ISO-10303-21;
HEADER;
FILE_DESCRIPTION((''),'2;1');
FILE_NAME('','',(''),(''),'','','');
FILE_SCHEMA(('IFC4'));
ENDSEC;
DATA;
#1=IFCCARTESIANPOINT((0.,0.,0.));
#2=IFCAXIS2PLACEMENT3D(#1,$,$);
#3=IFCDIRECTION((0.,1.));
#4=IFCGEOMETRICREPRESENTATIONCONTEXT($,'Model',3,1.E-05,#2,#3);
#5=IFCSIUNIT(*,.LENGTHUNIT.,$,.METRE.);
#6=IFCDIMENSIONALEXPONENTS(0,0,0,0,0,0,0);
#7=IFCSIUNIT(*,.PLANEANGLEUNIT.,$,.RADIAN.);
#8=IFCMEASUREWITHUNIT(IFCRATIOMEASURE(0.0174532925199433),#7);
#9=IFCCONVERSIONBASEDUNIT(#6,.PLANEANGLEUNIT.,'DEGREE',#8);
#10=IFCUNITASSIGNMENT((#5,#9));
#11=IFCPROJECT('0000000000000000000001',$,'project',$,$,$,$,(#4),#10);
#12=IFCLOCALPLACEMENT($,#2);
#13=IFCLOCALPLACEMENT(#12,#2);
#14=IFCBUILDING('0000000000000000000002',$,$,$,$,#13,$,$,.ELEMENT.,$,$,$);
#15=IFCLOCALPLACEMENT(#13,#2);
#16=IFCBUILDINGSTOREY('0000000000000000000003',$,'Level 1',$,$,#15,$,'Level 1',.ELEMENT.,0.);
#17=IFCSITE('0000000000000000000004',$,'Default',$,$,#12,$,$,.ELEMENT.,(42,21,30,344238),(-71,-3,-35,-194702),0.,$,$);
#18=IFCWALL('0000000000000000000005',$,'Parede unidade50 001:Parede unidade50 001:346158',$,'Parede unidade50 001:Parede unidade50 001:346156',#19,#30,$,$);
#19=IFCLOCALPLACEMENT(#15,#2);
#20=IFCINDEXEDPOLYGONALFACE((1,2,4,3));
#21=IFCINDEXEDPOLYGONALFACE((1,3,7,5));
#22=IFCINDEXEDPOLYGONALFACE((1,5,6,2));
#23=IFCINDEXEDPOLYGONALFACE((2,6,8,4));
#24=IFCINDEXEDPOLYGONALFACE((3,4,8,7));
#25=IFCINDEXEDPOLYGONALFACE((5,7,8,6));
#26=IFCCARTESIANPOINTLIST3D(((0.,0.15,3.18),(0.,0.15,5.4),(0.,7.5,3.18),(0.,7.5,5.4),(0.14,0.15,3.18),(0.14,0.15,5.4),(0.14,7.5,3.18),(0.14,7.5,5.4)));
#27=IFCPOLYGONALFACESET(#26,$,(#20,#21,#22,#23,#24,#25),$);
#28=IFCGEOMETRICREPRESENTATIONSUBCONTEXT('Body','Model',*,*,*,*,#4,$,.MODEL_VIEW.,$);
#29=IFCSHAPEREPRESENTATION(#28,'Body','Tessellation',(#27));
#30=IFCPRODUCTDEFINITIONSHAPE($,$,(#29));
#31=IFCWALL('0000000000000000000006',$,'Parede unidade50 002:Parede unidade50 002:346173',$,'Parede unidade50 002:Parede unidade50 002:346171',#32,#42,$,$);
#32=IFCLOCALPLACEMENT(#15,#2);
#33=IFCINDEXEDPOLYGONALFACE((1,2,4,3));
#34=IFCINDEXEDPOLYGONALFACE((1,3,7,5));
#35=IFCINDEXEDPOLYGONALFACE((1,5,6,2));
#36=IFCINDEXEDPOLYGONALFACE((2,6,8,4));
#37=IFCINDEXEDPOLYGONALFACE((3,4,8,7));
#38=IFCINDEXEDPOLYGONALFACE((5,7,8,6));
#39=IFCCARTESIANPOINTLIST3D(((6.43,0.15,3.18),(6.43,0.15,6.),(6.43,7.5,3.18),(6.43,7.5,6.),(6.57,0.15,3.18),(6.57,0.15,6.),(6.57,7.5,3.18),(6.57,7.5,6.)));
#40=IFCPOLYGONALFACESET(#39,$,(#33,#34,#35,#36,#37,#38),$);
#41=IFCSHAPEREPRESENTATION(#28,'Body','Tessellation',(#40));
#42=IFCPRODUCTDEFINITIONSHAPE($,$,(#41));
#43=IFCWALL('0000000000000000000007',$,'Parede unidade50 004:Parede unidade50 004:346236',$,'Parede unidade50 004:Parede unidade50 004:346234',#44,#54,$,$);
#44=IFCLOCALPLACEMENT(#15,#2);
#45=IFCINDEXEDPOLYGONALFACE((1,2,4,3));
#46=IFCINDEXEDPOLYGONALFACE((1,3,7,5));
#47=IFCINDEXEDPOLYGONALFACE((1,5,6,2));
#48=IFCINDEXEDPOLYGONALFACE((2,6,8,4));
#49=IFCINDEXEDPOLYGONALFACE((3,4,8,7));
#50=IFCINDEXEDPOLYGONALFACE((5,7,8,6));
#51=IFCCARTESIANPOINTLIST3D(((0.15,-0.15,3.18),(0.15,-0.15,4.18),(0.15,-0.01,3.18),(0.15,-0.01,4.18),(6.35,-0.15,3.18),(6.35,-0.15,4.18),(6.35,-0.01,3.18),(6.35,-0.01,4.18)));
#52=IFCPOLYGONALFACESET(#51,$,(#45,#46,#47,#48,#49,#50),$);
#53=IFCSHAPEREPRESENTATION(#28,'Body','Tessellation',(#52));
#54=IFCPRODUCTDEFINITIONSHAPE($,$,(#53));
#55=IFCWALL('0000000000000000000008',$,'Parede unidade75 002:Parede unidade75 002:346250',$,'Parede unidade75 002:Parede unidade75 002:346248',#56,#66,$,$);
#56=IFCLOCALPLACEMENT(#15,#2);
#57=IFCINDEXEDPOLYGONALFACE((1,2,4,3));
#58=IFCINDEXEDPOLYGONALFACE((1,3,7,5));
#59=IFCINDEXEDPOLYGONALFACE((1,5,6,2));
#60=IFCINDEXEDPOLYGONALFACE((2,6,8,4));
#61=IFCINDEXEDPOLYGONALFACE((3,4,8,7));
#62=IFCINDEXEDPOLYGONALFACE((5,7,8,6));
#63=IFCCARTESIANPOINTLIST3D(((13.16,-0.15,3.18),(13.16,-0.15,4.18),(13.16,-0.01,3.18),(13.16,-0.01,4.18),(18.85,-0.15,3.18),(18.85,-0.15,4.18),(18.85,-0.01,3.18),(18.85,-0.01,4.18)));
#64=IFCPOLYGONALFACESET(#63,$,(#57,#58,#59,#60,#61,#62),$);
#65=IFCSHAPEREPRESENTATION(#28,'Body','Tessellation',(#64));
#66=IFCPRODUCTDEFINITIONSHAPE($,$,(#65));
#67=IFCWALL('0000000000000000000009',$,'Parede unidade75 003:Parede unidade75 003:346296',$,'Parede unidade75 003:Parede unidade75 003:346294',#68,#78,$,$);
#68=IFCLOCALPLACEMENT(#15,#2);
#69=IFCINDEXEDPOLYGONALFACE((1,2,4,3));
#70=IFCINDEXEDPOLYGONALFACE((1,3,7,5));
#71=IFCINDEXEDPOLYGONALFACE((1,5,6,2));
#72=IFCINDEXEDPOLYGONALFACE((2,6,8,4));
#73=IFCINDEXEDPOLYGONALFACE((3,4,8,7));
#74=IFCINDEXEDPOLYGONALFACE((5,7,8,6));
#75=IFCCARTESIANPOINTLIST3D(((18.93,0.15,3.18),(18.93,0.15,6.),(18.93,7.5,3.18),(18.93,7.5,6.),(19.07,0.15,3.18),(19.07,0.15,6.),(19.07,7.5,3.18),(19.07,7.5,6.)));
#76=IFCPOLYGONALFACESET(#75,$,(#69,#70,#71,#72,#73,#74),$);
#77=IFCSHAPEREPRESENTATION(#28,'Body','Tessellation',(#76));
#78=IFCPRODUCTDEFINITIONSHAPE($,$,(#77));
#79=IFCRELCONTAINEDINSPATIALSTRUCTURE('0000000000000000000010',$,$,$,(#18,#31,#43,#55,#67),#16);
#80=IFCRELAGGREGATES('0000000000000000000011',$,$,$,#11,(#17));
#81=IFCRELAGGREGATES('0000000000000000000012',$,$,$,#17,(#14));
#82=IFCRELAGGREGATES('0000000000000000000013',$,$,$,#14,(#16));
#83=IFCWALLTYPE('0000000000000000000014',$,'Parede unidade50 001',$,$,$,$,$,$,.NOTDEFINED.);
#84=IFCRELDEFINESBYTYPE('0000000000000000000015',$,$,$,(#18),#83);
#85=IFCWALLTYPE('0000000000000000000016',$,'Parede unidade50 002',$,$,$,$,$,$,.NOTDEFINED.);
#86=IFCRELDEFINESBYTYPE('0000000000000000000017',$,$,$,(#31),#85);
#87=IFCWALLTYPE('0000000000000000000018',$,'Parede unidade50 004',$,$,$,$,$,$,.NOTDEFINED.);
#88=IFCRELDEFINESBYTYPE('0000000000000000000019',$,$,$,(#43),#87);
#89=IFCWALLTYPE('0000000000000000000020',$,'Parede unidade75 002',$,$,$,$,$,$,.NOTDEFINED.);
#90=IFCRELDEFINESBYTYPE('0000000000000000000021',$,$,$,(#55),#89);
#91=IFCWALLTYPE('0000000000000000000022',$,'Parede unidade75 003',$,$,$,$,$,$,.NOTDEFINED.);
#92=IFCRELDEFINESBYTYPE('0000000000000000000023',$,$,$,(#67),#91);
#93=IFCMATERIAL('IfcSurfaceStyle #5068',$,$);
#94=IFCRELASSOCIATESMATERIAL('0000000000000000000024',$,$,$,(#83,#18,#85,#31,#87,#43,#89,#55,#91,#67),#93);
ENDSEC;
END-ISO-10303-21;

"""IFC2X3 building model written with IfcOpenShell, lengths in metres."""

from ifc_helpers import new_model, entity, si_unit, converted_unit, direction, frame, frame_2d, origin, origin_2d_with_axis, place, context, subcontext, project, spatial, rectangle, extrude, material, type_object, element, save


model = new_model("IFC2X3")

# Units and contexts
model_context = context("Model", 3, precision=1e-05, world=origin(), true_north=direction((0.0, 1.0)))
body_context = subcontext(model_context, "Body", "Model", "MODEL_VIEW")
ifc_project = project(units=[si_unit("LENGTHUNIT", "METRE"), converted_unit("PLANEANGLEUNIT", "DEGREE", entity("IfcRatioMeasure", 0.0174532925199433), si_unit("PLANEANGLEUNIT", "RADIAN"), dimensions=[0, 0, 0, 0, 0, 0, 0])], contexts=[model_context])

# Site, building, storey
site_placement = place(None, origin())
site = spatial("IfcSite", under=ifc_project, at=site_placement, Name="Default", CompositionType="ELEMENT", RefLatitude=(42, 21, 30, 344238), RefLongitude=(-71, -3, -35, -194702), RefElevation=0.0)
building_placement = place(site_placement, origin())
building = spatial("IfcBuilding", under=site, at=building_placement, CompositionType="ELEMENT")
storey_placement = place(building_placement, origin())
storey = spatial("IfcBuildingStorey", under=building, at=storey_placement, Name="Level 1", LongName="Level 1", CompositionType="ELEMENT", Elevation=0.0)

# Walls
ifc_material_1 = material(Name="IfcSurfaceStyle #5068")
wall_type_1 = type_object("IfcWallType", Name="Parede unidade50 001", PredefinedType="NOTDEFINED", material=ifc_material_1)
wall_1_placement = place(storey_placement, frame((0.0, 0.15, 3.18), z_axis=(0.0, 0.0, 1.0), x_axis=(0.0, 1.0, 0.0)))
element("IfcWall", 1, at=wall_1_placement, inside=storey, type_object=wall_type_1, material=ifc_material_1, Name="Parede unidade50 001:Parede unidade50 001:346158", ObjectType="Parede unidade50 001:Parede unidade50 001:346156", context=body_context, shape_type="SweptSolid", body=[
    extrude(rectangle(XDim=0.14, YDim=7.35, at=origin_2d_with_axis()), frame((3.675, -0.07, 0.0), z_axis=(0.0, 0.0, 1.0), x_axis=(0.0, 1.0, 0.0)), (0.0, 0.0, 1.0), 2.22),
])
wall_type_2 = type_object("IfcWallType", Name="Parede unidade50 002", PredefinedType="NOTDEFINED", material=ifc_material_1)
wall_2_placement = place(storey_placement, frame((6.43, 0.15, 3.18), z_axis=(0.0, 0.0, 1.0), x_axis=(0.0, 1.0, 0.0)))
element("IfcWall", 2, at=wall_2_placement, inside=storey, type_object=wall_type_2, material=ifc_material_1, Name="Parede unidade50 002:Parede unidade50 002:346173", ObjectType="Parede unidade50 002:Parede unidade50 002:346171", context=body_context, shape_type="SweptSolid", body=[
    extrude(rectangle(XDim=0.14, YDim=7.35, at=origin_2d_with_axis()), frame((3.675, -0.07, 0.0), z_axis=(0.0, 0.0, 1.0), x_axis=(0.0, -1.0, 0.0)), (0.0, 0.0, 1.0), 2.82),
])

# Walls
wall_type_3 = type_object("IfcWallType", Name="Parede unidade50 004", PredefinedType="NOTDEFINED", material=ifc_material_1)
wall_3_placement = place(storey_placement, frame((0.15, -0.15, 3.18)))
element("IfcWall", 3, at=wall_3_placement, inside=storey, type_object=wall_type_3, material=ifc_material_1, Name="Parede unidade50 004:Parede unidade50 004:346236", ObjectType="Parede unidade50 004:Parede unidade50 004:346234", context=body_context, shape_type="SweptSolid", body=[
    extrude(rectangle(XDim=0.14, YDim=6.2, at=frame_2d((0.0, 0.0), x_axis=(1.0, 0.0))), frame((3.1, 0.07, 0.0), z_axis=(0.0, 0.0, 1.0), x_axis=(0.0, -1.0, 0.0)), (0.0, 0.0, 1.0), 1.0),
])
wall_type_4 = type_object("IfcWallType", Name="Parede unidade75 002", PredefinedType="NOTDEFINED", material=ifc_material_1)
wall_4_placement = place(storey_placement, frame((13.16, -0.15, 3.18)))
element("IfcWall", 4, at=wall_4_placement, inside=storey, type_object=wall_type_4, material=ifc_material_1, Name="Parede unidade75 002:Parede unidade75 002:346250", ObjectType="Parede unidade75 002:Parede unidade75 002:346248", context=body_context, shape_type="SweptSolid", body=[
    extrude(rectangle(XDim=0.14, YDim=5.69, at=frame_2d((0.0, 0.0), x_axis=(1.0, 0.0))), frame((2.845, 0.07, 0.0), z_axis=(0.0, 0.0, 1.0), x_axis=(0.0, -1.0, 0.0)), (0.0, 0.0, 1.0), 1.0),
])

# Wall
wall_type_5 = type_object("IfcWallType", Name="Parede unidade75 003", PredefinedType="NOTDEFINED", material=ifc_material_1)
wall_5_placement = place(storey_placement, frame((18.93, 0.15, 3.18), z_axis=(0.0, 0.0, 1.0), x_axis=(0.0, 1.0, 0.0)))
element("IfcWall", 5, at=wall_5_placement, inside=storey, type_object=wall_type_5, material=ifc_material_1, Name="Parede unidade75 003:Parede unidade75 003:346296", ObjectType="Parede unidade75 003:Parede unidade75 003:346294", context=body_context, shape_type="SweptSolid", body=[
    extrude(rectangle(XDim=0.14, YDim=7.35, at=frame_2d((0.0, 0.0), x_axis=(1.0, 0.0))), frame((3.675, -0.07, 0.0), z_axis=(0.0, 0.0, 1.0), x_axis=(0.0, -1.0, 0.0)), (0.0, 0.0, 1.0), 2.82),
])

save(model, "model.ifc")
